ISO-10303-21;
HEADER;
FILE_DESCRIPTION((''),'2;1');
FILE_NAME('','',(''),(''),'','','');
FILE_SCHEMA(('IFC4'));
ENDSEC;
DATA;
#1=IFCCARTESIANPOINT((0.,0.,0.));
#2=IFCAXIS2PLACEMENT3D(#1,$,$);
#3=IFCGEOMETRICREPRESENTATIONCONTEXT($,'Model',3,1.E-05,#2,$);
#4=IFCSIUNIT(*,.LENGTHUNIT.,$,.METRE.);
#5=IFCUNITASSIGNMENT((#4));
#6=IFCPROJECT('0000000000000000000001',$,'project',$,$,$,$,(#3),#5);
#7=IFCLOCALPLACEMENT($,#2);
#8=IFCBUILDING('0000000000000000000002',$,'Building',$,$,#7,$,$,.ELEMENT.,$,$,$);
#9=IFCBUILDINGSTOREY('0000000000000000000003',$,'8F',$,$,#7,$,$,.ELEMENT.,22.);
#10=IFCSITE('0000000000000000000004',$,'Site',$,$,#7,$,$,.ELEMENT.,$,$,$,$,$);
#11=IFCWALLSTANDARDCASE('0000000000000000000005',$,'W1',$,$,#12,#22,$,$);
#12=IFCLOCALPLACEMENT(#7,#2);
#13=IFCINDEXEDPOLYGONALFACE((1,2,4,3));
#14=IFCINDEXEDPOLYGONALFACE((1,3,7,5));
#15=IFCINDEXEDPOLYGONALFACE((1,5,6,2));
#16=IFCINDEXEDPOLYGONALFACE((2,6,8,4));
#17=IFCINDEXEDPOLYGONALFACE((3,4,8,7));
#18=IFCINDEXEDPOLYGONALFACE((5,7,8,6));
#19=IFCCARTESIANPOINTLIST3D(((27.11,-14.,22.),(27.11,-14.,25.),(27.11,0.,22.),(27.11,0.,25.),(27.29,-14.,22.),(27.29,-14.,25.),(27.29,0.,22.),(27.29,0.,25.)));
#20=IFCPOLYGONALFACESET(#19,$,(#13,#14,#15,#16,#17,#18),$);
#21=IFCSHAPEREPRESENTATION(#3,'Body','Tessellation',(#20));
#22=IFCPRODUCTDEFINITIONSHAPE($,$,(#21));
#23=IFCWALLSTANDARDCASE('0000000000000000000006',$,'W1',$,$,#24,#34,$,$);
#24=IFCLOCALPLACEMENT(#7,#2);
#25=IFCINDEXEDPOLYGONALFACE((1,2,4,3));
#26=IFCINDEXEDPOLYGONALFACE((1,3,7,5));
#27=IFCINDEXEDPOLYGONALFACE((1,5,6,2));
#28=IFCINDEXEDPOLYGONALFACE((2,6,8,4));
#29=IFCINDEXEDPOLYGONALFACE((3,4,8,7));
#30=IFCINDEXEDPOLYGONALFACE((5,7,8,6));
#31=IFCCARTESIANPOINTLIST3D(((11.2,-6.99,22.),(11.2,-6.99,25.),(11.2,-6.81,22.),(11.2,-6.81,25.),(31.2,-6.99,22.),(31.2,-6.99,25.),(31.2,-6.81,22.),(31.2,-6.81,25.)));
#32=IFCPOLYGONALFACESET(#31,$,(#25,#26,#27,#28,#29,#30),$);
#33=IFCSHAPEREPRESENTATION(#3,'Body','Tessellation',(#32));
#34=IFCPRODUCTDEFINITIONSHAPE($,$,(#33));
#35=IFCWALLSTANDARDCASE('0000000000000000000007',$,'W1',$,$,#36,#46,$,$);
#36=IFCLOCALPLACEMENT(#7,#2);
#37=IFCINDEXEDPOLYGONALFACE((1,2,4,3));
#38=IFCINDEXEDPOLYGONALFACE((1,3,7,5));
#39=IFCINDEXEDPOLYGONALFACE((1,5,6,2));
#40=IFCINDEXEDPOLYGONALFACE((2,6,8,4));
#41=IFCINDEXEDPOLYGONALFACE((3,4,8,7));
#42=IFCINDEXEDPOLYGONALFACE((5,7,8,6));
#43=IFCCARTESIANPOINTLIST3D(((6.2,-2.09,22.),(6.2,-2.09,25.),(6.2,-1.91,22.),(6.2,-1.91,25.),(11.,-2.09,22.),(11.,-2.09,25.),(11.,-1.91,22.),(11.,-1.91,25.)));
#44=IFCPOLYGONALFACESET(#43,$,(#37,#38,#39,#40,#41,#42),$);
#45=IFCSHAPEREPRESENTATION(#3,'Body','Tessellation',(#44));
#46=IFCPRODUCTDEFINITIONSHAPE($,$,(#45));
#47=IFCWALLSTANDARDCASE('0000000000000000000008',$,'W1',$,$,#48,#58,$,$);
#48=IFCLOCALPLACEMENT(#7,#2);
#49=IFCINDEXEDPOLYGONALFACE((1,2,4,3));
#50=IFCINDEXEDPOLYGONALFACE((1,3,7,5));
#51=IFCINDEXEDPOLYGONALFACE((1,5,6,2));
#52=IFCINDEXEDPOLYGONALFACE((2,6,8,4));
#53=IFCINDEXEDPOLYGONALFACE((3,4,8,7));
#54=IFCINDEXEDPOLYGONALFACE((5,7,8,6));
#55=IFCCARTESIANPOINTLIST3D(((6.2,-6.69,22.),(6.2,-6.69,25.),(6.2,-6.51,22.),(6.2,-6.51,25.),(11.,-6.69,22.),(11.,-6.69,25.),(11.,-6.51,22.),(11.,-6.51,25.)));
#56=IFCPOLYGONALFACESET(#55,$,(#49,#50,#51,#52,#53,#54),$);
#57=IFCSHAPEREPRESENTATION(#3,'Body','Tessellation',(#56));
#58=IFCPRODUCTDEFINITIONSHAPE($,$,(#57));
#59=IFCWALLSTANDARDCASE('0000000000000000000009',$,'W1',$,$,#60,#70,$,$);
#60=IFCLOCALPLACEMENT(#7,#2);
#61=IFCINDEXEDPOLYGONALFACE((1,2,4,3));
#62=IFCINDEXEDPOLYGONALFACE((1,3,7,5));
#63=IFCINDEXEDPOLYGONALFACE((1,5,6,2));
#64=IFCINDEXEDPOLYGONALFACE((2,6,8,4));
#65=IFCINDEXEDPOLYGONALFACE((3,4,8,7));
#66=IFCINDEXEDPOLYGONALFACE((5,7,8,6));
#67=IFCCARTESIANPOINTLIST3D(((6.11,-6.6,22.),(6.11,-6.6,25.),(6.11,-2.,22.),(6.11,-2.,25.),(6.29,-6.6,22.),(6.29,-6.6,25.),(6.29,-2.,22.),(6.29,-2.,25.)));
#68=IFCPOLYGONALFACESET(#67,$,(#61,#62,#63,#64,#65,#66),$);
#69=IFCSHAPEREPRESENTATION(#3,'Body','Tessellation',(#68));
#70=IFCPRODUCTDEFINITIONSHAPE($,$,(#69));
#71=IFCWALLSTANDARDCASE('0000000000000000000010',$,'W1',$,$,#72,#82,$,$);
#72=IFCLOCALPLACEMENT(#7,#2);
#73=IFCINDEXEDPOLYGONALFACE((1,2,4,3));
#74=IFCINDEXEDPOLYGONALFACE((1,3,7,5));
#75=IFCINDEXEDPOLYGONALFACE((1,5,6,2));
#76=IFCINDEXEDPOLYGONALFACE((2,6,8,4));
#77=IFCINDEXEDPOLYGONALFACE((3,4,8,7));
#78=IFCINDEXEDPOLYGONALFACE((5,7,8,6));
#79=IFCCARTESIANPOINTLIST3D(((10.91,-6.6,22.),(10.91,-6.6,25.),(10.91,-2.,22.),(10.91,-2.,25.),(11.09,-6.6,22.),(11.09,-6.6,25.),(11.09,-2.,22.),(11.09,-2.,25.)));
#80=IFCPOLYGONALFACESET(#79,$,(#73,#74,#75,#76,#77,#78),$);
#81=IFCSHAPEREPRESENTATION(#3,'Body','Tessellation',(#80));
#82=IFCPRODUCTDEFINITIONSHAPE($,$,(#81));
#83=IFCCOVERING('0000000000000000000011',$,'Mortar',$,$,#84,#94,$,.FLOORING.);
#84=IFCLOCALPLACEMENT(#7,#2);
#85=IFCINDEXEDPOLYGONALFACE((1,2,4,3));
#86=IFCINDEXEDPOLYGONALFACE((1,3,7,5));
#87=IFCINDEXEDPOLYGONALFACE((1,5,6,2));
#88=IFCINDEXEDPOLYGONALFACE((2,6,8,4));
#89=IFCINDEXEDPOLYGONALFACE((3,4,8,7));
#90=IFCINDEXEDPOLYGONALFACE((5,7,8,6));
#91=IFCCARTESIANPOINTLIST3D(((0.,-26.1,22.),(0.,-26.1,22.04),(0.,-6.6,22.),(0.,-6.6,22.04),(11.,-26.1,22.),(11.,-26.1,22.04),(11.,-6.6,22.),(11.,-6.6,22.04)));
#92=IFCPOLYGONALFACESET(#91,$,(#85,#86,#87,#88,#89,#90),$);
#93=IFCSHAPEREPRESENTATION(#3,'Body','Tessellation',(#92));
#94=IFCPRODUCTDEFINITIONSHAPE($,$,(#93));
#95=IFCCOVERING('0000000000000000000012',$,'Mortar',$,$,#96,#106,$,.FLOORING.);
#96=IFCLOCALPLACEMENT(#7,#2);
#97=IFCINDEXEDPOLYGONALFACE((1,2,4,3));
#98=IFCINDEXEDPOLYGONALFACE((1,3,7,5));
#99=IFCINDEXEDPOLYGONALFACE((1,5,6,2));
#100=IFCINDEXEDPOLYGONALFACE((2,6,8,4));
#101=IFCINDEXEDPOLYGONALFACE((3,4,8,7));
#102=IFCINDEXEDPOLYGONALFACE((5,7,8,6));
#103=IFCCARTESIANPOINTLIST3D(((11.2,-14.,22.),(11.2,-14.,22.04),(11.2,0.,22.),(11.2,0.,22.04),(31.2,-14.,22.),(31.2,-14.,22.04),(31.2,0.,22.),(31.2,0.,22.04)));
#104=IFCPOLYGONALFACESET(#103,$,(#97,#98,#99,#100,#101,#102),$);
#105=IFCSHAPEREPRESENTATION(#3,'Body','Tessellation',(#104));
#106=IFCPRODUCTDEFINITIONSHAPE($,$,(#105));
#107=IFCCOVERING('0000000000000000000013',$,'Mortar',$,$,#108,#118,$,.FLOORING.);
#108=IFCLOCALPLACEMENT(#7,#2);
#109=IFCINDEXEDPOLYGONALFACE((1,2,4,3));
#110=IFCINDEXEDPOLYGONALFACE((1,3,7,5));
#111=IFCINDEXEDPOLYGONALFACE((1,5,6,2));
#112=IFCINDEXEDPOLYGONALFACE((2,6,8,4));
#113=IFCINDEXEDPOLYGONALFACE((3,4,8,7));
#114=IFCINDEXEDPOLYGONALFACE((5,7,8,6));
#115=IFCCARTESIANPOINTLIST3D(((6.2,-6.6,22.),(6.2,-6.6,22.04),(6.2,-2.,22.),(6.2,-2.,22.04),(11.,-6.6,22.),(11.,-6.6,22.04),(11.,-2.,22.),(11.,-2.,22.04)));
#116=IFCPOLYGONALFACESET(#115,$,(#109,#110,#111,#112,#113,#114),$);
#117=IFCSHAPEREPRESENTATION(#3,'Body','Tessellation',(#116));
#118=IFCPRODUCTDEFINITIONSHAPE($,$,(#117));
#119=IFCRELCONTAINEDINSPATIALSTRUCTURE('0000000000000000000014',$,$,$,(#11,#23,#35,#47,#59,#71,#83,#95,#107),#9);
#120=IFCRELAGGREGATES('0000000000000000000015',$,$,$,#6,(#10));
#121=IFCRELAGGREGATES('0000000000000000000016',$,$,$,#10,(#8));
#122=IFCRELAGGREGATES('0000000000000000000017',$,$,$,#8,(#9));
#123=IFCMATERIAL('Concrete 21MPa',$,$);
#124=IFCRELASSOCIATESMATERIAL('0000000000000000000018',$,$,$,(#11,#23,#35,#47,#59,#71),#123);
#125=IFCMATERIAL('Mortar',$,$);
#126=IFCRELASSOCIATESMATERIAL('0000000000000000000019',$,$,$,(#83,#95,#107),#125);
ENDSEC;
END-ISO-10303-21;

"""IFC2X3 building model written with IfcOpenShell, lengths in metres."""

from ifc_helpers import new_model, si_unit, frame, origin, origin_2d, place, context, project, spatial, rectangle, extrude, material, element, save


model = new_model("IFC2X3")

# Units and contexts
model_context = context("Model", 3, precision=1e-05, world=origin())
ifc_project = project(units=[si_unit("LENGTHUNIT", "METRE")], contexts=[model_context])

# Site, building, storey
placement = place(None, origin())
site = spatial("IfcSite", under=ifc_project, at=placement, Name="Site", CompositionType="ELEMENT")
building = spatial("IfcBuilding", under=site, at=placement, Name="Building", CompositionType="ELEMENT")
storey = spatial("IfcBuildingStorey", under=building, at=placement, Name="8F", CompositionType="ELEMENT", Elevation=22.0)

# Shared definitions
ifc_material_1 = material(Name="Concrete 21MPa")

# Walls
for number, where, name in (
    (1, (27.2, -7.0, 22.0), "W1"),
):
    element("IfcWallStandardCase", number, at=place(None, frame(where)), inside=storey, material=ifc_material_1, Name=name, context=model_context, shape_type="SweptSolid", body=[
        extrude(rectangle(XDim=0.18, YDim=14.0, at=origin_2d()), origin(), (0.0, 0.0, 1.0), 3.0),
    ])
wall_1_placement = place(None, frame((21.2, -6.9, 22.0)))
element("IfcWallStandardCase", 2, at=wall_1_placement, inside=storey, material=ifc_material_1, Name="W1", context=model_context, shape_type="SweptSolid", body=[
    extrude(rectangle(XDim=20.0, YDim=0.18, at=origin_2d()), origin(), (0.0, 0.0, 1.0), 3.0),
])
for number, where, name in (
    (3, (8.6, -2.0, 22.0), "W1"),
    (4, (8.6, -6.6, 22.0), "W1"),
):
    element("IfcWallStandardCase", number, at=place(None, frame(where)), inside=storey, material=ifc_material_1, Name=name, context=model_context, shape_type="SweptSolid", body=[
        extrude(rectangle(XDim=4.8, YDim=0.18, at=origin_2d()), origin(), (0.0, 0.0, 1.0), 3.0),
    ])
for number, where, name in (
    (5, (6.2, -4.3, 22.0), "W1"),
    (6, (11.0, -4.3, 22.0), "W1"),
):
    element("IfcWallStandardCase", number, at=place(None, frame(where)), inside=storey, material=ifc_material_1, Name=name, context=model_context, shape_type="SweptSolid", body=[
        extrude(rectangle(XDim=0.18, YDim=4.6, at=origin_2d()), origin(), (0.0, 0.0, 1.0), 3.0),
    ])

# Coverings
ifc_material_2 = material(Name="Mortar")
covering_1_placement = place(None, frame((5.5, -16.35, 22.0)))
element("IfcCovering", 7, at=covering_1_placement, inside=storey, material=ifc_material_2, Name="Mortar", PredefinedType="FLOORING", context=model_context, shape_type="SweptSolid", body=[
    extrude(rectangle(XDim=11.0, YDim=19.5, at=origin_2d()), origin(), (0.0, 0.0, 1.0), 0.04),
])
covering_2_placement = place(None, frame((21.2, -7.0, 22.0)))
element("IfcCovering", 8, at=covering_2_placement, inside=storey, material=ifc_material_2, Name="Mortar", PredefinedType="FLOORING", context=model_context, shape_type="SweptSolid", body=[
    extrude(rectangle(XDim=20.0, YDim=14.0, at=origin_2d()), origin(), (0.0, 0.0, 1.0), 0.04),
])
covering_3_placement = place(None, frame((8.6, -4.3, 22.0)))
element("IfcCovering", 9, at=covering_3_placement, inside=storey, material=ifc_material_2, Name="Mortar", PredefinedType="FLOORING", context=model_context, shape_type="SweptSolid", body=[
    extrude(rectangle(XDim=4.8, YDim=4.6, at=origin_2d()), origin(), (0.0, 0.0, 1.0), 0.04),
])

save(model, "model.ifc")
